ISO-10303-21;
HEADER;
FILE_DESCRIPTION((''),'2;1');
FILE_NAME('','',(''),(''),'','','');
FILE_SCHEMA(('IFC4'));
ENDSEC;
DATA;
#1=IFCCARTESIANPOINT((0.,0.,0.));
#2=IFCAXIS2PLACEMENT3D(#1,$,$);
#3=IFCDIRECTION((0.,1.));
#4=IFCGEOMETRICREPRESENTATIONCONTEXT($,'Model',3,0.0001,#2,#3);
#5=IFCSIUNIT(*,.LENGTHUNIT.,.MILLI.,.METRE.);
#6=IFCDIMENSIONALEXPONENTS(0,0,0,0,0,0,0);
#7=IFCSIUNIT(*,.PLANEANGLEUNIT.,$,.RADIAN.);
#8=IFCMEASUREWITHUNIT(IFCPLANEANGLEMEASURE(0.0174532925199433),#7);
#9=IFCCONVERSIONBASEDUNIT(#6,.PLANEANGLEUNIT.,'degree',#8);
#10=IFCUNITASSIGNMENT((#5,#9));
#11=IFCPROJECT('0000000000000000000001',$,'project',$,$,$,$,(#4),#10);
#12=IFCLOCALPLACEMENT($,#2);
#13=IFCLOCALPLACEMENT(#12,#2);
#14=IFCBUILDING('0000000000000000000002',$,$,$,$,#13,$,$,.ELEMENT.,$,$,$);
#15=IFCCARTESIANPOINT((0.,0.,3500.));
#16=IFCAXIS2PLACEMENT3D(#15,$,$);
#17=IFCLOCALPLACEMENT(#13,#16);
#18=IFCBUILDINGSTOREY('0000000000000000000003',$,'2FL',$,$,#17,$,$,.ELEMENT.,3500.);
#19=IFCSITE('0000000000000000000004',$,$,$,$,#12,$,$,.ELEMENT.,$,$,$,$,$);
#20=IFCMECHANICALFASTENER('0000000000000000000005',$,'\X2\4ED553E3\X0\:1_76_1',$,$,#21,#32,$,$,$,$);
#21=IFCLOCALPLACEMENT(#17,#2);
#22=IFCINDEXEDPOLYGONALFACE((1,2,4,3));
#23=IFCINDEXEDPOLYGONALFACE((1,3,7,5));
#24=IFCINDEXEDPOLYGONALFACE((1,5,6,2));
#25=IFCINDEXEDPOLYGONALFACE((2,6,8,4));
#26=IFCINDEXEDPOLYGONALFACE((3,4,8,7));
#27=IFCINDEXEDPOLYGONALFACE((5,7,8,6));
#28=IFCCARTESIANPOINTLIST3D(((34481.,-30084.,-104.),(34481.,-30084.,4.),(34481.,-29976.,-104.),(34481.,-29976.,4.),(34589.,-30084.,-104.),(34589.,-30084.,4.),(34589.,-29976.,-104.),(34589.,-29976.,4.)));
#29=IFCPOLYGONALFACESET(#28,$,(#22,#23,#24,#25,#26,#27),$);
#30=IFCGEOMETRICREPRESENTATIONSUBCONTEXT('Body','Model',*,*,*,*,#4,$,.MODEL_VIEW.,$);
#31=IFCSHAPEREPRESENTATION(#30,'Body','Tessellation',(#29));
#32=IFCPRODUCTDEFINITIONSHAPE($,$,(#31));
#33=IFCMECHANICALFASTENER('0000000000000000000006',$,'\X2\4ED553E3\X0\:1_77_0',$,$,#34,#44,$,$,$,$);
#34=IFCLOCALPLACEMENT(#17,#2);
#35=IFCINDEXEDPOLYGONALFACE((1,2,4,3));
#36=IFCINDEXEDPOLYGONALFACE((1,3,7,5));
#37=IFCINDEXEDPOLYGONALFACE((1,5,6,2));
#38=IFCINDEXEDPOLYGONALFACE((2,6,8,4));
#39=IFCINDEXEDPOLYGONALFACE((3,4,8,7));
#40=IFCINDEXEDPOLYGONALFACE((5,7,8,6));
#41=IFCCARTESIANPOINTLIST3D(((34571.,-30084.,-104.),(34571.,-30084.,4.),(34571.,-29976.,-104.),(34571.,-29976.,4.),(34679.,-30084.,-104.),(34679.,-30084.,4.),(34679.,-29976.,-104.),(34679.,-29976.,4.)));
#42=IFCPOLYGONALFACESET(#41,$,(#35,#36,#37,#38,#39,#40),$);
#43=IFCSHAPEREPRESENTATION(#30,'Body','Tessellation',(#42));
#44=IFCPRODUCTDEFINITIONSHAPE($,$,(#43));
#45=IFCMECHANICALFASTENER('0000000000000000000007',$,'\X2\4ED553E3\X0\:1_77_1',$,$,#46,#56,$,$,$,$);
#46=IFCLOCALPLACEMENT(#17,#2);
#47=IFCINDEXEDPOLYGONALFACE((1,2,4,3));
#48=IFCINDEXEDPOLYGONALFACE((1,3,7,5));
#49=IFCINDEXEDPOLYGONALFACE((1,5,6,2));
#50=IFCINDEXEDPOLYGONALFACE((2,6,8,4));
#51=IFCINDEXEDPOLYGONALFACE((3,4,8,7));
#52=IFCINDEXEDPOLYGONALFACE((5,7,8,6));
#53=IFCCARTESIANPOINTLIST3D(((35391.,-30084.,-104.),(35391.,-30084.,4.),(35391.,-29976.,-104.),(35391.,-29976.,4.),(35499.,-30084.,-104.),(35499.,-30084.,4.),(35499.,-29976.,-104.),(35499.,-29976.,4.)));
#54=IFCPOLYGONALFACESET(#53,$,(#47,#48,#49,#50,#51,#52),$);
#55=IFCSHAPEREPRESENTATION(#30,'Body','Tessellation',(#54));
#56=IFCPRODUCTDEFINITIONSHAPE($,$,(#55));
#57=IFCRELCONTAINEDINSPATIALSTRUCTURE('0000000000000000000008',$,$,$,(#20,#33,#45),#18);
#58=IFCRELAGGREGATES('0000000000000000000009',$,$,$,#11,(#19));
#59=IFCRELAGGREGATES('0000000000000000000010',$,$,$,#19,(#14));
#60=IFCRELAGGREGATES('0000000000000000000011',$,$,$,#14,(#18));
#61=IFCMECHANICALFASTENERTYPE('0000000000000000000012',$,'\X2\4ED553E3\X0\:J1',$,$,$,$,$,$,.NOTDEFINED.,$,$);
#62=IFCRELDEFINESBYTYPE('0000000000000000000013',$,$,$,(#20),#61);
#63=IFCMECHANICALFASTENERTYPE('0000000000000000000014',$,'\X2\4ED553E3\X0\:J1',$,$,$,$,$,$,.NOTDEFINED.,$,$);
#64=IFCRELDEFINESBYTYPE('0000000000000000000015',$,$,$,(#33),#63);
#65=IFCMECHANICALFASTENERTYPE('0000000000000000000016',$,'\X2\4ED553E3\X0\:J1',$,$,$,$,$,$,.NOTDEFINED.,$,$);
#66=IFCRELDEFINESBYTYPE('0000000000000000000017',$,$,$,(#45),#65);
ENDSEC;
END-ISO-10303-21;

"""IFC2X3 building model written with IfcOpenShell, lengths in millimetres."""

from ifc_helpers import new_model, entity, si_unit, converted_unit, direction, frame, origin, origin_with_axes, origin_2d, place, context, subcontext, project, spatial, rectangle, extrude, type_object, element, save


model = new_model("IFC2X3")

# Units and contexts
model_context = context("Model", 3, precision=0.0001, world=origin(), true_north=direction((0.0, 1.0)))
body_context = subcontext(model_context, "Body", "Model", "MODEL_VIEW")
ifc_project = project(units=[si_unit("LENGTHUNIT", "METRE", prefix="MILLI"), converted_unit("PLANEANGLEUNIT", "degree", entity("IfcPlaneAngleMeasure", 0.0174532925199433), si_unit("PLANEANGLEUNIT", "RADIAN"), dimensions=[0, 0, 0, 0, 0, 0, 0])], contexts=[model_context])

# Site, building, storey
site_placement = place(None, origin())
site = spatial("IfcSite", under=ifc_project, at=site_placement, CompositionType="ELEMENT")
building_placement = place(site_placement, origin())
building = spatial("IfcBuilding", under=site, at=building_placement, CompositionType="ELEMENT")
storey_placement = place(building_placement, frame((0.0, 0.0, 3500.0)))
storey = spatial("IfcBuildingStorey", under=building, at=storey_placement, Name="2FL", CompositionType="ELEMENT", Elevation=3500.0)

# Mechanical fasteners
mechanical_fastener_type_1 = type_object("IfcMechanicalFastenerType", Name="仕口:J1")
mechanical_fastener_1_placement = place(storey_placement, frame((34535.0, -30030.0, -104.0)))
element("IfcMechanicalFastener", 1, at=mechanical_fastener_1_placement, inside=storey, type_object=mechanical_fastener_type_1, Name="仕口:1_76_1", context=body_context, shape_type="SweptSolid", body=[
    extrude(rectangle(XDim=108.0, YDim=108.0, at=origin_2d()), origin_with_axes(), (0.0, 0.0, 1.0), 108.0),
])
mechanical_fastener_type_2 = type_object("IfcMechanicalFastenerType", Name="仕口:J1")
mechanical_fastener_2_placement = place(storey_placement, frame((34625.0, -30030.0, -104.0)))
element("IfcMechanicalFastener", 2, at=mechanical_fastener_2_placement, inside=storey, type_object=mechanical_fastener_type_2, Name="仕口:1_77_0", context=body_context, shape_type="SweptSolid", body=[
    extrude(rectangle(XDim=108.0, YDim=108.0, at=origin_2d()), origin_with_axes(), (0.0, 0.0, 1.0), 108.0),
])
mechanical_fastener_type_3 = type_object("IfcMechanicalFastenerType", Name="仕口:J1")
mechanical_fastener_3_placement = place(storey_placement, frame((35445.0, -30030.0, -104.0)))
element("IfcMechanicalFastener", 3, at=mechanical_fastener_3_placement, inside=storey, type_object=mechanical_fastener_type_3, Name="仕口:1_77_1", context=body_context, shape_type="SweptSolid", body=[
    extrude(rectangle(XDim=108.0, YDim=108.0, at=origin_2d()), origin_with_axes(), (0.0, 0.0, 1.0), 108.0),
])

save(model, "model.ifc")
